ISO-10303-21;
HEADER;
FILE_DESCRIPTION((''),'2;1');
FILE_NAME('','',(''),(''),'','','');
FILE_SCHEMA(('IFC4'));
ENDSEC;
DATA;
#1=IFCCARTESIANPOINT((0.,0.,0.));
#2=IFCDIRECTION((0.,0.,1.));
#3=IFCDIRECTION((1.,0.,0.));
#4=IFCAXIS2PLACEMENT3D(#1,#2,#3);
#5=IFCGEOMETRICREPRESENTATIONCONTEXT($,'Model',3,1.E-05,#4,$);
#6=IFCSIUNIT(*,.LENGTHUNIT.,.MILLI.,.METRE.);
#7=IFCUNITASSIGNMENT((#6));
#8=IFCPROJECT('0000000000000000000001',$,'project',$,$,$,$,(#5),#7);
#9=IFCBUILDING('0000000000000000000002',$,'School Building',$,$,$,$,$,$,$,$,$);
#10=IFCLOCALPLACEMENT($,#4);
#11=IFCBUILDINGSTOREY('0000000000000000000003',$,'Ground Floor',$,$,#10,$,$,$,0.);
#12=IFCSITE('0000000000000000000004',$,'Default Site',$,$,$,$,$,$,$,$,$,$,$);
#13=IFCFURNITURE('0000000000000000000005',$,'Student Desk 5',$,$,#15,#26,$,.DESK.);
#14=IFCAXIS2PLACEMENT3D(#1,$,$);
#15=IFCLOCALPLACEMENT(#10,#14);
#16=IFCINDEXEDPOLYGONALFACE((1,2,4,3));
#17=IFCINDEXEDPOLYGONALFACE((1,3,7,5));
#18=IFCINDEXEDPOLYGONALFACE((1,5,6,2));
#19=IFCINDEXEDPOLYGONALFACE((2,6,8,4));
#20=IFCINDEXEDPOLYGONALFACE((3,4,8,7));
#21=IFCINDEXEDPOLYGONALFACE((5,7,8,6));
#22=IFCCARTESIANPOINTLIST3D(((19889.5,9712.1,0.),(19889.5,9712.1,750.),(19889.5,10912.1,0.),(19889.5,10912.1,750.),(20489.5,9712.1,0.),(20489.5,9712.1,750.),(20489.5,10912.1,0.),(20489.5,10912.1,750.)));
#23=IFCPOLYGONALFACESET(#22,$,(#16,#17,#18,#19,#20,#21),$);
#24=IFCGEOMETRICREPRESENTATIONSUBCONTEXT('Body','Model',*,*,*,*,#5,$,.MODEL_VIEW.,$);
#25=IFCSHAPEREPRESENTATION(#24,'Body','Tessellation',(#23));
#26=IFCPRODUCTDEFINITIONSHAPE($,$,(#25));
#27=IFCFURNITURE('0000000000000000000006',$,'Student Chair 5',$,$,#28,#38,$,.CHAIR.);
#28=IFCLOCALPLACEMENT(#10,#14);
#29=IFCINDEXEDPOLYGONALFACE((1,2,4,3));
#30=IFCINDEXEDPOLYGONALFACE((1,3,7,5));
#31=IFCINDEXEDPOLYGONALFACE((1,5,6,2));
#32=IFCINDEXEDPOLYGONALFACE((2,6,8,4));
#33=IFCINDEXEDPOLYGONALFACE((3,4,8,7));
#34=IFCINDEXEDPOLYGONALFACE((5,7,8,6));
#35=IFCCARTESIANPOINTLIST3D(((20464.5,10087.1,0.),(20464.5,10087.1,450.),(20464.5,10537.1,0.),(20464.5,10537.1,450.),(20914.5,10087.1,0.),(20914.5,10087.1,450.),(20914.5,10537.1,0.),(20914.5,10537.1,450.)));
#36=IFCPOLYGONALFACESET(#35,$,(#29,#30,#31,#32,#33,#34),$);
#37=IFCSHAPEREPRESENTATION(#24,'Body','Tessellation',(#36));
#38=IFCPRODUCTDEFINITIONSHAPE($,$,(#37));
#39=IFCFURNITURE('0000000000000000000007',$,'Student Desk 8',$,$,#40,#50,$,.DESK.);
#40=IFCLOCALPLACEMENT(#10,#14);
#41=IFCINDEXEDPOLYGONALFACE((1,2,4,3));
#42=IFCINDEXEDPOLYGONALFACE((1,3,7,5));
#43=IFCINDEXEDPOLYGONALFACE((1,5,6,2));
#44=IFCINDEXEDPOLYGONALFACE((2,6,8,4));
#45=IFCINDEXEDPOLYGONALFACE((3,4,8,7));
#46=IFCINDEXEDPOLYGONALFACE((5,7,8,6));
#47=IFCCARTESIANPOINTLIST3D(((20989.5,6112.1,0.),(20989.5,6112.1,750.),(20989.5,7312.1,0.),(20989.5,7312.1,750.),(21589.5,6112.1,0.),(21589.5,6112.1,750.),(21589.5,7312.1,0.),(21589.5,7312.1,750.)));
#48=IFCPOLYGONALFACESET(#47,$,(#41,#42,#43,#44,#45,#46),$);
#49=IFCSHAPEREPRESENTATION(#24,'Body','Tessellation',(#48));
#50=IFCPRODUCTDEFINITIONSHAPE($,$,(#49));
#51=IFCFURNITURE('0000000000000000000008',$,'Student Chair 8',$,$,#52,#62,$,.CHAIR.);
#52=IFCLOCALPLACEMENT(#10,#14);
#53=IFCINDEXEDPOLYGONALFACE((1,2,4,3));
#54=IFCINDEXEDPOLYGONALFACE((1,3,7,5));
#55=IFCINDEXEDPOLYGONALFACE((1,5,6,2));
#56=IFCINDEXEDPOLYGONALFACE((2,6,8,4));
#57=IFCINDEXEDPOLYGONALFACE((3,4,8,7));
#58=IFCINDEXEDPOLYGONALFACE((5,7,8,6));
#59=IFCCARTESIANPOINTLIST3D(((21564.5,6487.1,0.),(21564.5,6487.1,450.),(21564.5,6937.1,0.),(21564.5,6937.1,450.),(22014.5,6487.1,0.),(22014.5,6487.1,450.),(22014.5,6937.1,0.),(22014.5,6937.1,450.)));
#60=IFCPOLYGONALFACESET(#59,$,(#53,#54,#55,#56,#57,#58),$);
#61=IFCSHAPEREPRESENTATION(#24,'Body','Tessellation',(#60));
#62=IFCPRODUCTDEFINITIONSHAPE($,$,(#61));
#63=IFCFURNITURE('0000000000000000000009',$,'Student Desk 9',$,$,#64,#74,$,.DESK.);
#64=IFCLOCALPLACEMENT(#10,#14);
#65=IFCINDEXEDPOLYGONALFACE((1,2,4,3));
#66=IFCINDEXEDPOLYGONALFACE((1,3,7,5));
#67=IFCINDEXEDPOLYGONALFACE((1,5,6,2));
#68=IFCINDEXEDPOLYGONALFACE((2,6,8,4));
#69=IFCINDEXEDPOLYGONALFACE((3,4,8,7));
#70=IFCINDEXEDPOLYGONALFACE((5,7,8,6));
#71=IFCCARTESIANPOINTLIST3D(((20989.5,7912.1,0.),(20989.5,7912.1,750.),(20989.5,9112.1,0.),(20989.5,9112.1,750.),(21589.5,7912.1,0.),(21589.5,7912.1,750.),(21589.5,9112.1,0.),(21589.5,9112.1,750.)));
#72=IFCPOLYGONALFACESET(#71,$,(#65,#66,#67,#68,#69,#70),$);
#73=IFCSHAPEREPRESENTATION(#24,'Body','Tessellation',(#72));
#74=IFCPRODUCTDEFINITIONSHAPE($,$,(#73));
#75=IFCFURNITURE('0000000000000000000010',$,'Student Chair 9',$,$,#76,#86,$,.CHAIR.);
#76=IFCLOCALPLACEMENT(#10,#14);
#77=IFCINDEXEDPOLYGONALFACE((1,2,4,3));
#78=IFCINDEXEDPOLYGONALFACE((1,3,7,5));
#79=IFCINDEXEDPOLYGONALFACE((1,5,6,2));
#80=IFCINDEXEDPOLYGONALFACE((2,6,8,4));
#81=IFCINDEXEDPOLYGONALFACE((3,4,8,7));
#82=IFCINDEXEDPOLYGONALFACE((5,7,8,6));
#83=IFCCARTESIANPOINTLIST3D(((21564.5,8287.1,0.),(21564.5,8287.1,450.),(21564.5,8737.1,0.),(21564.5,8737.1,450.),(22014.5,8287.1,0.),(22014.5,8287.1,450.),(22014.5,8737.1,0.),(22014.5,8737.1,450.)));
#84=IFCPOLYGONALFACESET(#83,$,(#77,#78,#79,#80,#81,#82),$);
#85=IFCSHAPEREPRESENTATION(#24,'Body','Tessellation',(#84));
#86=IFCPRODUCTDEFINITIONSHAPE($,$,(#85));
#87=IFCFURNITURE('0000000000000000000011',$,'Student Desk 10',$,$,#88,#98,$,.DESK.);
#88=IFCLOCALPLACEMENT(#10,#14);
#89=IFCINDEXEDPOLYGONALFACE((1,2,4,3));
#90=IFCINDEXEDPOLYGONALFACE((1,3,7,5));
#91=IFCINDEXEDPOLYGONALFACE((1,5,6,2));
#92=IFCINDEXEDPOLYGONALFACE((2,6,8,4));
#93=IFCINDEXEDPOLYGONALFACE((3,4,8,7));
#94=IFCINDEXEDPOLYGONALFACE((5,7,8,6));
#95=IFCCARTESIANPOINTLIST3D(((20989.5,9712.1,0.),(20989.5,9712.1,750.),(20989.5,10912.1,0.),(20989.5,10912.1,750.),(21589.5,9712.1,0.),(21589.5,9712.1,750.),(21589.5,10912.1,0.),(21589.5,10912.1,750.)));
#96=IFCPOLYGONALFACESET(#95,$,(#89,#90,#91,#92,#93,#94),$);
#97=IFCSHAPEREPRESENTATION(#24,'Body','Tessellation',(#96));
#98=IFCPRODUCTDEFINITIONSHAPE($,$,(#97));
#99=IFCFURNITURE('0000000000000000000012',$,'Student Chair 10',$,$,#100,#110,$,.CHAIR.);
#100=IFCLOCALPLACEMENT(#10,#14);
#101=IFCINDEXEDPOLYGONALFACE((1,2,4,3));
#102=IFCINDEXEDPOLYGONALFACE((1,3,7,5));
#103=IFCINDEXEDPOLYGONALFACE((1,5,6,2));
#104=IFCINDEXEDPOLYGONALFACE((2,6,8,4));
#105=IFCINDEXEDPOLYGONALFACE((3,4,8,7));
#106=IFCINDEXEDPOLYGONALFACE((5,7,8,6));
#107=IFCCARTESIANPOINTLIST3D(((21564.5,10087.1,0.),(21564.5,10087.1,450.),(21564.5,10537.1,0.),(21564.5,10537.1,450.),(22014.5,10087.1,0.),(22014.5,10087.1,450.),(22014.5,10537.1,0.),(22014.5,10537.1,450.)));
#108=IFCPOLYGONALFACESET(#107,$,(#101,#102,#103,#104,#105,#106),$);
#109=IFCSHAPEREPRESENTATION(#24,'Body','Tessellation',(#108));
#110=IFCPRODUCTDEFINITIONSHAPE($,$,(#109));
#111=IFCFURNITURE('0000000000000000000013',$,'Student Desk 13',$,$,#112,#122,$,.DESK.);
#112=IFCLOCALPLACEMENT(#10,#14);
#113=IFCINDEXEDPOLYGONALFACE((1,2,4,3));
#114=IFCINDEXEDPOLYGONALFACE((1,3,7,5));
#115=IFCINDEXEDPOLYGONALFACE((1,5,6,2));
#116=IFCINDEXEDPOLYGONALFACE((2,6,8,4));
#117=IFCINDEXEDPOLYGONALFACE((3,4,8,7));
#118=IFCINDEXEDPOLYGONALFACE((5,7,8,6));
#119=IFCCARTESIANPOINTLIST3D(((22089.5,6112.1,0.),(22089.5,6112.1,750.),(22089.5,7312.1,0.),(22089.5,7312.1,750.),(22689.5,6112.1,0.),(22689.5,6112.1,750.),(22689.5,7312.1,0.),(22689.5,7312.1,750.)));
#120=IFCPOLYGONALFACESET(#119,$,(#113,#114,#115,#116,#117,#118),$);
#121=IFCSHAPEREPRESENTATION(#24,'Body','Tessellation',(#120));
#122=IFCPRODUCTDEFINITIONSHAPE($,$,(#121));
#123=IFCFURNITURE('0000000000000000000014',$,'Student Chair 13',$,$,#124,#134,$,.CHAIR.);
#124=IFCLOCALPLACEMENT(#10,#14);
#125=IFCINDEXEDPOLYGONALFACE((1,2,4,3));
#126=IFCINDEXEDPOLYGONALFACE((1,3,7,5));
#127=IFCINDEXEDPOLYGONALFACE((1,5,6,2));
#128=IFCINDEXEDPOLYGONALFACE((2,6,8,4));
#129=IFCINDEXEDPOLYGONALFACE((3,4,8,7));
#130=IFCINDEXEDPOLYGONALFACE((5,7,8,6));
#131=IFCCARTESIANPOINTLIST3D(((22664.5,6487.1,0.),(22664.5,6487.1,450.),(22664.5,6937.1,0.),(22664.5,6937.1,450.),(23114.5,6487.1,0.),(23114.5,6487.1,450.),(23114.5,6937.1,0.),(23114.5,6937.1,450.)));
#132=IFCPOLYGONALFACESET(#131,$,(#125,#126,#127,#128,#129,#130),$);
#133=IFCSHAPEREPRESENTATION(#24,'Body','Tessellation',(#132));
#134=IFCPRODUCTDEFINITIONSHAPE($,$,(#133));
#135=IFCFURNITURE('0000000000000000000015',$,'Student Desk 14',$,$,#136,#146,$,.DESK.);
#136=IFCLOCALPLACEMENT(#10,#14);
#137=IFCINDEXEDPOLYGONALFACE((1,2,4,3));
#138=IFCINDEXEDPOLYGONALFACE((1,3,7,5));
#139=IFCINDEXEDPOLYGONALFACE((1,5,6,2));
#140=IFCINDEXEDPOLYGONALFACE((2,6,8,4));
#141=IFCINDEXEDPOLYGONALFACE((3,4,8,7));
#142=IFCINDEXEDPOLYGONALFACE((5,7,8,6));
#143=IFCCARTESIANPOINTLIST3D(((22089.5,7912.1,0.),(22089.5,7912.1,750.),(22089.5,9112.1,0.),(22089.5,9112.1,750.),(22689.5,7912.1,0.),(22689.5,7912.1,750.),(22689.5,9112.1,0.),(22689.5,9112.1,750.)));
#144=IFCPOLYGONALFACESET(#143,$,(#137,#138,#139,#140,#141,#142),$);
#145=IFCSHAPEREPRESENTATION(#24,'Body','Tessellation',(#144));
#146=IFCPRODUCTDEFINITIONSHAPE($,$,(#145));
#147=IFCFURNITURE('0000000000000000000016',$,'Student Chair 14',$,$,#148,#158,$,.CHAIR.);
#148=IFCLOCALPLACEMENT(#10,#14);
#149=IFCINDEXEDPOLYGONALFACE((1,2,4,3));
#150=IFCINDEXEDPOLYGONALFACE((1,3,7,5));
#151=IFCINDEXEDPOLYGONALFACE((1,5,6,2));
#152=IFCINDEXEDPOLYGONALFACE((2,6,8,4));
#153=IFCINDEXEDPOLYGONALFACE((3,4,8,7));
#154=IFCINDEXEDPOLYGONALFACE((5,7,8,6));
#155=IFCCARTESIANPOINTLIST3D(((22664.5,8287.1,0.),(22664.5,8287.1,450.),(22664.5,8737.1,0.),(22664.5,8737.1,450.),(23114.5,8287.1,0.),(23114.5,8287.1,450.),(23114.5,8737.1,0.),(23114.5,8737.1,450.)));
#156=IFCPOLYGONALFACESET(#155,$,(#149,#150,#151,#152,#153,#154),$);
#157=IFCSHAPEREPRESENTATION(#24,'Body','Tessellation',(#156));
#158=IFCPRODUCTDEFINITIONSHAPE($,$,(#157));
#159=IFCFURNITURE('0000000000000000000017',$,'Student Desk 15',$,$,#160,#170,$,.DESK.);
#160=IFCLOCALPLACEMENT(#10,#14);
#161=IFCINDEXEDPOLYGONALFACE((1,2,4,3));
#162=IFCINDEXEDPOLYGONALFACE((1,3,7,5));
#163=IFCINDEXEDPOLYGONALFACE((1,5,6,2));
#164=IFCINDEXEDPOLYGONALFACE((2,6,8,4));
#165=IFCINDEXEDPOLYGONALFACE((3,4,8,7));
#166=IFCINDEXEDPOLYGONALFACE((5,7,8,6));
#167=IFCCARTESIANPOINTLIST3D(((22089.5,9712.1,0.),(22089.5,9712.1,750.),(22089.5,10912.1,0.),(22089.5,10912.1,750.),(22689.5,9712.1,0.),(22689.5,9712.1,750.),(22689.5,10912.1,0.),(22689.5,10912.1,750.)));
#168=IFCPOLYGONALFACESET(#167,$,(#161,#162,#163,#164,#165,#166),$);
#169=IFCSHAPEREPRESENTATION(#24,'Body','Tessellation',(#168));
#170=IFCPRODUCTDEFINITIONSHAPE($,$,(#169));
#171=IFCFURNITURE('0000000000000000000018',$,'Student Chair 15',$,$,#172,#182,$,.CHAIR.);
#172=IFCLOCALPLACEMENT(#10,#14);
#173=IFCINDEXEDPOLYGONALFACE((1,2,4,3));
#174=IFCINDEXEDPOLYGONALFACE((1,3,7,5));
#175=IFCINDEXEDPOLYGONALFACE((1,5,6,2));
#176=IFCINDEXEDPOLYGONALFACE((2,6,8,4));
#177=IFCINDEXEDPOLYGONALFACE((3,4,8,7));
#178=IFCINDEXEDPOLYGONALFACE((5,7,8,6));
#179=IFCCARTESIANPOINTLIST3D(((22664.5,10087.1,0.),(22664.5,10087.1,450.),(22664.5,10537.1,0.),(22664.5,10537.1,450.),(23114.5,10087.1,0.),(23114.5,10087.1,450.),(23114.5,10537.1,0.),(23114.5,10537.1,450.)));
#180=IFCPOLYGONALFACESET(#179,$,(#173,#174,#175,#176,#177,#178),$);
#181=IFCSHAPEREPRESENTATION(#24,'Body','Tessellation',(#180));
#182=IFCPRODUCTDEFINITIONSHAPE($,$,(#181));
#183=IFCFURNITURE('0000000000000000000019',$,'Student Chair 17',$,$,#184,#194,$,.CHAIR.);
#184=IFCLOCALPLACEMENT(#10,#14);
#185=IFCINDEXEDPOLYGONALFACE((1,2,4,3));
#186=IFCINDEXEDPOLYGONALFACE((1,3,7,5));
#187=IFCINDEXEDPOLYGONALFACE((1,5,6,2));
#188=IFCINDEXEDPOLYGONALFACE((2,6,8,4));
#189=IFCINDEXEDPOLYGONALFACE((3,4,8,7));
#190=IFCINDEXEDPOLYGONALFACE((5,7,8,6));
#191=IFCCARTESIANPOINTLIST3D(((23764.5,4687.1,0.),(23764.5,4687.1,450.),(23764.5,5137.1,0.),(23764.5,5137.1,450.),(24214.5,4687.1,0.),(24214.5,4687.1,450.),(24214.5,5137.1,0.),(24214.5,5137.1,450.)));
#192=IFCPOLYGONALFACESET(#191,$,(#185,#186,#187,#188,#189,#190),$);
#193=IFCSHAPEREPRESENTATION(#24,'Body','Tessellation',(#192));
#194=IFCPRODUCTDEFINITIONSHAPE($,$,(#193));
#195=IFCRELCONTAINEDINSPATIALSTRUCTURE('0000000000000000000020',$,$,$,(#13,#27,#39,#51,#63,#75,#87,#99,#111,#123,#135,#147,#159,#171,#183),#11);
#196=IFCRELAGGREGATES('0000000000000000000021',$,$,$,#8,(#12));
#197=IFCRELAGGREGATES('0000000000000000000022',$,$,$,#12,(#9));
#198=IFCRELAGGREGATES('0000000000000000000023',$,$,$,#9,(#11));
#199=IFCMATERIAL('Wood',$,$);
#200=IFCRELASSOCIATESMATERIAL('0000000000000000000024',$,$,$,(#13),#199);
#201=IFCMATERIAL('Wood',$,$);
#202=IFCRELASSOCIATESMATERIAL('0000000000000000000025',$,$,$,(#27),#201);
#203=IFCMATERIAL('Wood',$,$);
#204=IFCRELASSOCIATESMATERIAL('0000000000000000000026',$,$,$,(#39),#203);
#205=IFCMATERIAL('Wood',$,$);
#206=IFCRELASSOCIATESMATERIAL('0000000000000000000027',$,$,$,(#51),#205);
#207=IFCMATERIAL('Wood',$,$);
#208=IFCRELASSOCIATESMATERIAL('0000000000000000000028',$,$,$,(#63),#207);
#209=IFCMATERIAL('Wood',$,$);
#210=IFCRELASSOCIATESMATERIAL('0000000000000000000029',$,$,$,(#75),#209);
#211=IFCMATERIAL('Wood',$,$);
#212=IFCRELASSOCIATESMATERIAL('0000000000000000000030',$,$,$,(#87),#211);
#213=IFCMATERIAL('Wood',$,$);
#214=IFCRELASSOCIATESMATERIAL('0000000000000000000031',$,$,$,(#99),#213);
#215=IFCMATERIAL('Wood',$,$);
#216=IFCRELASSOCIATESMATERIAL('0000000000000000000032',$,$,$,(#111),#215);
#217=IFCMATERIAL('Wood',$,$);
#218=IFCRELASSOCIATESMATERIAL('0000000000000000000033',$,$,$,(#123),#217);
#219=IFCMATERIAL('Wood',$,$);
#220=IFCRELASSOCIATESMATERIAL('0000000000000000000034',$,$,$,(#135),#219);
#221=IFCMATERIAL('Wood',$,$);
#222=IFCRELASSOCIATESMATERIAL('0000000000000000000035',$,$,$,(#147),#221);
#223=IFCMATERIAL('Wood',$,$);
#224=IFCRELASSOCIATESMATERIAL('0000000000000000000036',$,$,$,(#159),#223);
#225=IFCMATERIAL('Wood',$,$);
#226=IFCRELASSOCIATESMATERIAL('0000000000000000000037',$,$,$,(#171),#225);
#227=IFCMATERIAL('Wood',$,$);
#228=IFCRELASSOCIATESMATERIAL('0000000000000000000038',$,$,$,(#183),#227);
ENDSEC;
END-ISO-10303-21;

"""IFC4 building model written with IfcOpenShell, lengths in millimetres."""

from ifc_helpers import new_model, si_unit, frame, origin_with_axes, origin_2d, place, context, subcontext, project, spatial, rectangle, extrude, material, element, save


model = new_model("IFC4")

# Units and contexts
model_context = context("Model", 3, precision=1e-05, world=origin_with_axes())
body_context = subcontext(model_context, "Body", "Model", "MODEL_VIEW")
ifc_project = project(units=[si_unit("LENGTHUNIT", "METRE", prefix="MILLI")], contexts=[model_context])

# Site, building, storey
site = spatial("IfcSite", under=ifc_project, Name="Default Site")
building = spatial("IfcBuilding", under=site, Name="School Building")
storey_placement = place(None, origin_with_axes())
storey = spatial("IfcBuildingStorey", under=building, at=storey_placement, Name="Ground Floor", Elevation=0.0)

# Furniture
ifc_material_1 = material(Name="Wood")
furniture_1_placement = place(storey_placement, frame((20189.5, 10312.1, 0.0), z_axis=(0.0, 0.0, 1.0), x_axis=(0.0, 1.0, 0.0)))
element("IfcFurniture", 1, at=furniture_1_placement, inside=storey, material=ifc_material_1, Name="Student Desk 5", PredefinedType="DESK", context=body_context, shape_type="SweptSolid", body=[
    extrude(rectangle(XDim=1200.0, YDim=600.0, at=origin_2d()), origin_with_axes(), (0.0, 0.0, 1.0), 750.0),
])
ifc_material_2 = material(Name="Wood")
furniture_2_placement = place(storey_placement, frame((20689.5, 10312.1, 0.0), z_axis=(0.0, 0.0, 1.0), x_axis=(1.0, 0.0, 0.0)))
element("IfcFurniture", 2, at=furniture_2_placement, inside=storey, material=ifc_material_2, Name="Student Chair 5", PredefinedType="CHAIR", context=body_context, shape_type="SweptSolid", body=[
    extrude(rectangle(XDim=450.0, YDim=450.0, at=origin_2d()), origin_with_axes(), (0.0, 0.0, 1.0), 450.0),
])
ifc_material_3 = material(Name="Wood")
furniture_3_placement = place(storey_placement, frame((21289.5, 6712.1, 0.0), z_axis=(0.0, 0.0, 1.0), x_axis=(0.0, 1.0, 0.0)))
element("IfcFurniture", 3, at=furniture_3_placement, inside=storey, material=ifc_material_3, Name="Student Desk 8", PredefinedType="DESK", context=body_context, shape_type="SweptSolid", body=[
    extrude(rectangle(XDim=1200.0, YDim=600.0, at=origin_2d()), origin_with_axes(), (0.0, 0.0, 1.0), 750.0),
])
ifc_material_4 = material(Name="Wood")
furniture_4_placement = place(storey_placement, frame((21789.5, 6712.1, 0.0), z_axis=(0.0, 0.0, 1.0), x_axis=(1.0, 0.0, 0.0)))
element("IfcFurniture", 4, at=furniture_4_placement, inside=storey, material=ifc_material_4, Name="Student Chair 8", PredefinedType="CHAIR", context=body_context, shape_type="SweptSolid", body=[
    extrude(rectangle(XDim=450.0, YDim=450.0, at=origin_2d()), origin_with_axes(), (0.0, 0.0, 1.0), 450.0),
])
ifc_material_5 = material(Name="Wood")
furniture_5_placement = place(storey_placement, frame((21289.5, 8512.1, 0.0), z_axis=(0.0, 0.0, 1.0), x_axis=(0.0, 1.0, 0.0)))
element("IfcFurniture", 5, at=furniture_5_placement, inside=storey, material=ifc_material_5, Name="Student Desk 9", PredefinedType="DESK", context=body_context, shape_type="SweptSolid", body=[
    extrude(rectangle(XDim=1200.0, YDim=600.0, at=origin_2d()), origin_with_axes(), (0.0, 0.0, 1.0), 750.0),
])
ifc_material_6 = material(Name="Wood")
furniture_6_placement = place(storey_placement, frame((21789.5, 8512.1, 0.0), z_axis=(0.0, 0.0, 1.0), x_axis=(1.0, 0.0, 0.0)))
element("IfcFurniture", 6, at=furniture_6_placement, inside=storey, material=ifc_material_6, Name="Student Chair 9", PredefinedType="CHAIR", context=body_context, shape_type="SweptSolid", body=[
    extrude(rectangle(XDim=450.0, YDim=450.0, at=origin_2d()), origin_with_axes(), (0.0, 0.0, 1.0), 450.0),
])
ifc_material_7 = material(Name="Wood")
furniture_7_placement = place(storey_placement, frame((21289.5, 10312.1, 0.0), z_axis=(0.0, 0.0, 1.0), x_axis=(0.0, 1.0, 0.0)))
element("IfcFurniture", 7, at=furniture_7_placement, inside=storey, material=ifc_material_7, Name="Student Desk 10", PredefinedType="DESK", context=body_context, shape_type="SweptSolid", body=[
    extrude(rectangle(XDim=1200.0, YDim=600.0, at=origin_2d()), origin_with_axes(), (0.0, 0.0, 1.0), 750.0),
])
ifc_material_8 = material(Name="Wood")
furniture_8_placement = place(storey_placement, frame((21789.5, 10312.1, 0.0), z_axis=(0.0, 0.0, 1.0), x_axis=(1.0, 0.0, 0.0)))
element("IfcFurniture", 8, at=furniture_8_placement, inside=storey, material=ifc_material_8, Name="Student Chair 10", PredefinedType="CHAIR", context=body_context, shape_type="SweptSolid", body=[
    extrude(rectangle(XDim=450.0, YDim=450.0, at=origin_2d()), origin_with_axes(), (0.0, 0.0, 1.0), 450.0),
])
ifc_material_9 = material(Name="Wood")
furniture_9_placement = place(storey_placement, frame((22389.5, 6712.1, 0.0), z_axis=(0.0, 0.0, 1.0), x_axis=(0.0, 1.0, 0.0)))
element("IfcFurniture", 9, at=furniture_9_placement, inside=storey, material=ifc_material_9, Name="Student Desk 13", PredefinedType="DESK", context=body_context, shape_type="SweptSolid", body=[
    extrude(rectangle(XDim=1200.0, YDim=600.0, at=origin_2d()), origin_with_axes(), (0.0, 0.0, 1.0), 750.0),
])
ifc_material_10 = material(Name="Wood")
furniture_10_placement = place(storey_placement, frame((22889.5, 6712.1, 0.0), z_axis=(0.0, 0.0, 1.0), x_axis=(1.0, 0.0, 0.0)))
element("IfcFurniture", 10, at=furniture_10_placement, inside=storey, material=ifc_material_10, Name="Student Chair 13", PredefinedType="CHAIR", context=body_context, shape_type="SweptSolid", body=[
    extrude(rectangle(XDim=450.0, YDim=450.0, at=origin_2d()), origin_with_axes(), (0.0, 0.0, 1.0), 450.0),
])
ifc_material_11 = material(Name="Wood")
furniture_11_placement = place(storey_placement, frame((22389.5, 8512.1, 0.0), z_axis=(0.0, 0.0, 1.0), x_axis=(0.0, 1.0, 0.0)))
element("IfcFurniture", 11, at=furniture_11_placement, inside=storey, material=ifc_material_11, Name="Student Desk 14", PredefinedType="DESK", context=body_context, shape_type="SweptSolid", body=[
    extrude(rectangle(XDim=1200.0, YDim=600.0, at=origin_2d()), origin_with_axes(), (0.0, 0.0, 1.0), 750.0),
])
ifc_material_12 = material(Name="Wood")
furniture_12_placement = place(storey_placement, frame((22889.5, 8512.1, 0.0), z_axis=(0.0, 0.0, 1.0), x_axis=(1.0, 0.0, 0.0)))
element("IfcFurniture", 12, at=furniture_12_placement, inside=storey, material=ifc_material_12, Name="Student Chair 14", PredefinedType="CHAIR", context=body_context, shape_type="SweptSolid", body=[
    extrude(rectangle(XDim=450.0, YDim=450.0, at=origin_2d()), origin_with_axes(), (0.0, 0.0, 1.0), 450.0),
])
ifc_material_13 = material(Name="Wood")
furniture_13_placement = place(storey_placement, frame((22389.5, 10312.1, 0.0), z_axis=(0.0, 0.0, 1.0), x_axis=(0.0, 1.0, 0.0)))
element("IfcFurniture", 13, at=furniture_13_placement, inside=storey, material=ifc_material_13, Name="Student Desk 15", PredefinedType="DESK", context=body_context, shape_type="SweptSolid", body=[
    extrude(rectangle(XDim=1200.0, YDim=600.0, at=origin_2d()), origin_with_axes(), (0.0, 0.0, 1.0), 750.0),
])
ifc_material_14 = material(Name="Wood")
furniture_14_placement = place(storey_placement, frame((22889.5, 10312.1, 0.0), z_axis=(0.0, 0.0, 1.0), x_axis=(1.0, 0.0, 0.0)))
element("IfcFurniture", 14, at=furniture_14_placement, inside=storey, material=ifc_material_14, Name="Student Chair 15", PredefinedType="CHAIR", context=body_context, shape_type="SweptSolid", body=[
    extrude(rectangle(XDim=450.0, YDim=450.0, at=origin_2d()), origin_with_axes(), (0.0, 0.0, 1.0), 450.0),
])
ifc_material_15 = material(Name="Wood")
furniture_15_placement = place(storey_placement, frame((23989.5, 4912.1, 0.0), z_axis=(0.0, 0.0, 1.0), x_axis=(1.0, 0.0, 0.0)))
element("IfcFurniture", 15, at=furniture_15_placement, inside=storey, material=ifc_material_15, Name="Student Chair 17", PredefinedType="CHAIR", context=body_context, shape_type="SweptSolid", body=[
    extrude(rectangle(XDim=450.0, YDim=450.0, at=origin_2d()), origin_with_axes(), (0.0, 0.0, 1.0), 450.0),
])

save(model, "model.ifc")
